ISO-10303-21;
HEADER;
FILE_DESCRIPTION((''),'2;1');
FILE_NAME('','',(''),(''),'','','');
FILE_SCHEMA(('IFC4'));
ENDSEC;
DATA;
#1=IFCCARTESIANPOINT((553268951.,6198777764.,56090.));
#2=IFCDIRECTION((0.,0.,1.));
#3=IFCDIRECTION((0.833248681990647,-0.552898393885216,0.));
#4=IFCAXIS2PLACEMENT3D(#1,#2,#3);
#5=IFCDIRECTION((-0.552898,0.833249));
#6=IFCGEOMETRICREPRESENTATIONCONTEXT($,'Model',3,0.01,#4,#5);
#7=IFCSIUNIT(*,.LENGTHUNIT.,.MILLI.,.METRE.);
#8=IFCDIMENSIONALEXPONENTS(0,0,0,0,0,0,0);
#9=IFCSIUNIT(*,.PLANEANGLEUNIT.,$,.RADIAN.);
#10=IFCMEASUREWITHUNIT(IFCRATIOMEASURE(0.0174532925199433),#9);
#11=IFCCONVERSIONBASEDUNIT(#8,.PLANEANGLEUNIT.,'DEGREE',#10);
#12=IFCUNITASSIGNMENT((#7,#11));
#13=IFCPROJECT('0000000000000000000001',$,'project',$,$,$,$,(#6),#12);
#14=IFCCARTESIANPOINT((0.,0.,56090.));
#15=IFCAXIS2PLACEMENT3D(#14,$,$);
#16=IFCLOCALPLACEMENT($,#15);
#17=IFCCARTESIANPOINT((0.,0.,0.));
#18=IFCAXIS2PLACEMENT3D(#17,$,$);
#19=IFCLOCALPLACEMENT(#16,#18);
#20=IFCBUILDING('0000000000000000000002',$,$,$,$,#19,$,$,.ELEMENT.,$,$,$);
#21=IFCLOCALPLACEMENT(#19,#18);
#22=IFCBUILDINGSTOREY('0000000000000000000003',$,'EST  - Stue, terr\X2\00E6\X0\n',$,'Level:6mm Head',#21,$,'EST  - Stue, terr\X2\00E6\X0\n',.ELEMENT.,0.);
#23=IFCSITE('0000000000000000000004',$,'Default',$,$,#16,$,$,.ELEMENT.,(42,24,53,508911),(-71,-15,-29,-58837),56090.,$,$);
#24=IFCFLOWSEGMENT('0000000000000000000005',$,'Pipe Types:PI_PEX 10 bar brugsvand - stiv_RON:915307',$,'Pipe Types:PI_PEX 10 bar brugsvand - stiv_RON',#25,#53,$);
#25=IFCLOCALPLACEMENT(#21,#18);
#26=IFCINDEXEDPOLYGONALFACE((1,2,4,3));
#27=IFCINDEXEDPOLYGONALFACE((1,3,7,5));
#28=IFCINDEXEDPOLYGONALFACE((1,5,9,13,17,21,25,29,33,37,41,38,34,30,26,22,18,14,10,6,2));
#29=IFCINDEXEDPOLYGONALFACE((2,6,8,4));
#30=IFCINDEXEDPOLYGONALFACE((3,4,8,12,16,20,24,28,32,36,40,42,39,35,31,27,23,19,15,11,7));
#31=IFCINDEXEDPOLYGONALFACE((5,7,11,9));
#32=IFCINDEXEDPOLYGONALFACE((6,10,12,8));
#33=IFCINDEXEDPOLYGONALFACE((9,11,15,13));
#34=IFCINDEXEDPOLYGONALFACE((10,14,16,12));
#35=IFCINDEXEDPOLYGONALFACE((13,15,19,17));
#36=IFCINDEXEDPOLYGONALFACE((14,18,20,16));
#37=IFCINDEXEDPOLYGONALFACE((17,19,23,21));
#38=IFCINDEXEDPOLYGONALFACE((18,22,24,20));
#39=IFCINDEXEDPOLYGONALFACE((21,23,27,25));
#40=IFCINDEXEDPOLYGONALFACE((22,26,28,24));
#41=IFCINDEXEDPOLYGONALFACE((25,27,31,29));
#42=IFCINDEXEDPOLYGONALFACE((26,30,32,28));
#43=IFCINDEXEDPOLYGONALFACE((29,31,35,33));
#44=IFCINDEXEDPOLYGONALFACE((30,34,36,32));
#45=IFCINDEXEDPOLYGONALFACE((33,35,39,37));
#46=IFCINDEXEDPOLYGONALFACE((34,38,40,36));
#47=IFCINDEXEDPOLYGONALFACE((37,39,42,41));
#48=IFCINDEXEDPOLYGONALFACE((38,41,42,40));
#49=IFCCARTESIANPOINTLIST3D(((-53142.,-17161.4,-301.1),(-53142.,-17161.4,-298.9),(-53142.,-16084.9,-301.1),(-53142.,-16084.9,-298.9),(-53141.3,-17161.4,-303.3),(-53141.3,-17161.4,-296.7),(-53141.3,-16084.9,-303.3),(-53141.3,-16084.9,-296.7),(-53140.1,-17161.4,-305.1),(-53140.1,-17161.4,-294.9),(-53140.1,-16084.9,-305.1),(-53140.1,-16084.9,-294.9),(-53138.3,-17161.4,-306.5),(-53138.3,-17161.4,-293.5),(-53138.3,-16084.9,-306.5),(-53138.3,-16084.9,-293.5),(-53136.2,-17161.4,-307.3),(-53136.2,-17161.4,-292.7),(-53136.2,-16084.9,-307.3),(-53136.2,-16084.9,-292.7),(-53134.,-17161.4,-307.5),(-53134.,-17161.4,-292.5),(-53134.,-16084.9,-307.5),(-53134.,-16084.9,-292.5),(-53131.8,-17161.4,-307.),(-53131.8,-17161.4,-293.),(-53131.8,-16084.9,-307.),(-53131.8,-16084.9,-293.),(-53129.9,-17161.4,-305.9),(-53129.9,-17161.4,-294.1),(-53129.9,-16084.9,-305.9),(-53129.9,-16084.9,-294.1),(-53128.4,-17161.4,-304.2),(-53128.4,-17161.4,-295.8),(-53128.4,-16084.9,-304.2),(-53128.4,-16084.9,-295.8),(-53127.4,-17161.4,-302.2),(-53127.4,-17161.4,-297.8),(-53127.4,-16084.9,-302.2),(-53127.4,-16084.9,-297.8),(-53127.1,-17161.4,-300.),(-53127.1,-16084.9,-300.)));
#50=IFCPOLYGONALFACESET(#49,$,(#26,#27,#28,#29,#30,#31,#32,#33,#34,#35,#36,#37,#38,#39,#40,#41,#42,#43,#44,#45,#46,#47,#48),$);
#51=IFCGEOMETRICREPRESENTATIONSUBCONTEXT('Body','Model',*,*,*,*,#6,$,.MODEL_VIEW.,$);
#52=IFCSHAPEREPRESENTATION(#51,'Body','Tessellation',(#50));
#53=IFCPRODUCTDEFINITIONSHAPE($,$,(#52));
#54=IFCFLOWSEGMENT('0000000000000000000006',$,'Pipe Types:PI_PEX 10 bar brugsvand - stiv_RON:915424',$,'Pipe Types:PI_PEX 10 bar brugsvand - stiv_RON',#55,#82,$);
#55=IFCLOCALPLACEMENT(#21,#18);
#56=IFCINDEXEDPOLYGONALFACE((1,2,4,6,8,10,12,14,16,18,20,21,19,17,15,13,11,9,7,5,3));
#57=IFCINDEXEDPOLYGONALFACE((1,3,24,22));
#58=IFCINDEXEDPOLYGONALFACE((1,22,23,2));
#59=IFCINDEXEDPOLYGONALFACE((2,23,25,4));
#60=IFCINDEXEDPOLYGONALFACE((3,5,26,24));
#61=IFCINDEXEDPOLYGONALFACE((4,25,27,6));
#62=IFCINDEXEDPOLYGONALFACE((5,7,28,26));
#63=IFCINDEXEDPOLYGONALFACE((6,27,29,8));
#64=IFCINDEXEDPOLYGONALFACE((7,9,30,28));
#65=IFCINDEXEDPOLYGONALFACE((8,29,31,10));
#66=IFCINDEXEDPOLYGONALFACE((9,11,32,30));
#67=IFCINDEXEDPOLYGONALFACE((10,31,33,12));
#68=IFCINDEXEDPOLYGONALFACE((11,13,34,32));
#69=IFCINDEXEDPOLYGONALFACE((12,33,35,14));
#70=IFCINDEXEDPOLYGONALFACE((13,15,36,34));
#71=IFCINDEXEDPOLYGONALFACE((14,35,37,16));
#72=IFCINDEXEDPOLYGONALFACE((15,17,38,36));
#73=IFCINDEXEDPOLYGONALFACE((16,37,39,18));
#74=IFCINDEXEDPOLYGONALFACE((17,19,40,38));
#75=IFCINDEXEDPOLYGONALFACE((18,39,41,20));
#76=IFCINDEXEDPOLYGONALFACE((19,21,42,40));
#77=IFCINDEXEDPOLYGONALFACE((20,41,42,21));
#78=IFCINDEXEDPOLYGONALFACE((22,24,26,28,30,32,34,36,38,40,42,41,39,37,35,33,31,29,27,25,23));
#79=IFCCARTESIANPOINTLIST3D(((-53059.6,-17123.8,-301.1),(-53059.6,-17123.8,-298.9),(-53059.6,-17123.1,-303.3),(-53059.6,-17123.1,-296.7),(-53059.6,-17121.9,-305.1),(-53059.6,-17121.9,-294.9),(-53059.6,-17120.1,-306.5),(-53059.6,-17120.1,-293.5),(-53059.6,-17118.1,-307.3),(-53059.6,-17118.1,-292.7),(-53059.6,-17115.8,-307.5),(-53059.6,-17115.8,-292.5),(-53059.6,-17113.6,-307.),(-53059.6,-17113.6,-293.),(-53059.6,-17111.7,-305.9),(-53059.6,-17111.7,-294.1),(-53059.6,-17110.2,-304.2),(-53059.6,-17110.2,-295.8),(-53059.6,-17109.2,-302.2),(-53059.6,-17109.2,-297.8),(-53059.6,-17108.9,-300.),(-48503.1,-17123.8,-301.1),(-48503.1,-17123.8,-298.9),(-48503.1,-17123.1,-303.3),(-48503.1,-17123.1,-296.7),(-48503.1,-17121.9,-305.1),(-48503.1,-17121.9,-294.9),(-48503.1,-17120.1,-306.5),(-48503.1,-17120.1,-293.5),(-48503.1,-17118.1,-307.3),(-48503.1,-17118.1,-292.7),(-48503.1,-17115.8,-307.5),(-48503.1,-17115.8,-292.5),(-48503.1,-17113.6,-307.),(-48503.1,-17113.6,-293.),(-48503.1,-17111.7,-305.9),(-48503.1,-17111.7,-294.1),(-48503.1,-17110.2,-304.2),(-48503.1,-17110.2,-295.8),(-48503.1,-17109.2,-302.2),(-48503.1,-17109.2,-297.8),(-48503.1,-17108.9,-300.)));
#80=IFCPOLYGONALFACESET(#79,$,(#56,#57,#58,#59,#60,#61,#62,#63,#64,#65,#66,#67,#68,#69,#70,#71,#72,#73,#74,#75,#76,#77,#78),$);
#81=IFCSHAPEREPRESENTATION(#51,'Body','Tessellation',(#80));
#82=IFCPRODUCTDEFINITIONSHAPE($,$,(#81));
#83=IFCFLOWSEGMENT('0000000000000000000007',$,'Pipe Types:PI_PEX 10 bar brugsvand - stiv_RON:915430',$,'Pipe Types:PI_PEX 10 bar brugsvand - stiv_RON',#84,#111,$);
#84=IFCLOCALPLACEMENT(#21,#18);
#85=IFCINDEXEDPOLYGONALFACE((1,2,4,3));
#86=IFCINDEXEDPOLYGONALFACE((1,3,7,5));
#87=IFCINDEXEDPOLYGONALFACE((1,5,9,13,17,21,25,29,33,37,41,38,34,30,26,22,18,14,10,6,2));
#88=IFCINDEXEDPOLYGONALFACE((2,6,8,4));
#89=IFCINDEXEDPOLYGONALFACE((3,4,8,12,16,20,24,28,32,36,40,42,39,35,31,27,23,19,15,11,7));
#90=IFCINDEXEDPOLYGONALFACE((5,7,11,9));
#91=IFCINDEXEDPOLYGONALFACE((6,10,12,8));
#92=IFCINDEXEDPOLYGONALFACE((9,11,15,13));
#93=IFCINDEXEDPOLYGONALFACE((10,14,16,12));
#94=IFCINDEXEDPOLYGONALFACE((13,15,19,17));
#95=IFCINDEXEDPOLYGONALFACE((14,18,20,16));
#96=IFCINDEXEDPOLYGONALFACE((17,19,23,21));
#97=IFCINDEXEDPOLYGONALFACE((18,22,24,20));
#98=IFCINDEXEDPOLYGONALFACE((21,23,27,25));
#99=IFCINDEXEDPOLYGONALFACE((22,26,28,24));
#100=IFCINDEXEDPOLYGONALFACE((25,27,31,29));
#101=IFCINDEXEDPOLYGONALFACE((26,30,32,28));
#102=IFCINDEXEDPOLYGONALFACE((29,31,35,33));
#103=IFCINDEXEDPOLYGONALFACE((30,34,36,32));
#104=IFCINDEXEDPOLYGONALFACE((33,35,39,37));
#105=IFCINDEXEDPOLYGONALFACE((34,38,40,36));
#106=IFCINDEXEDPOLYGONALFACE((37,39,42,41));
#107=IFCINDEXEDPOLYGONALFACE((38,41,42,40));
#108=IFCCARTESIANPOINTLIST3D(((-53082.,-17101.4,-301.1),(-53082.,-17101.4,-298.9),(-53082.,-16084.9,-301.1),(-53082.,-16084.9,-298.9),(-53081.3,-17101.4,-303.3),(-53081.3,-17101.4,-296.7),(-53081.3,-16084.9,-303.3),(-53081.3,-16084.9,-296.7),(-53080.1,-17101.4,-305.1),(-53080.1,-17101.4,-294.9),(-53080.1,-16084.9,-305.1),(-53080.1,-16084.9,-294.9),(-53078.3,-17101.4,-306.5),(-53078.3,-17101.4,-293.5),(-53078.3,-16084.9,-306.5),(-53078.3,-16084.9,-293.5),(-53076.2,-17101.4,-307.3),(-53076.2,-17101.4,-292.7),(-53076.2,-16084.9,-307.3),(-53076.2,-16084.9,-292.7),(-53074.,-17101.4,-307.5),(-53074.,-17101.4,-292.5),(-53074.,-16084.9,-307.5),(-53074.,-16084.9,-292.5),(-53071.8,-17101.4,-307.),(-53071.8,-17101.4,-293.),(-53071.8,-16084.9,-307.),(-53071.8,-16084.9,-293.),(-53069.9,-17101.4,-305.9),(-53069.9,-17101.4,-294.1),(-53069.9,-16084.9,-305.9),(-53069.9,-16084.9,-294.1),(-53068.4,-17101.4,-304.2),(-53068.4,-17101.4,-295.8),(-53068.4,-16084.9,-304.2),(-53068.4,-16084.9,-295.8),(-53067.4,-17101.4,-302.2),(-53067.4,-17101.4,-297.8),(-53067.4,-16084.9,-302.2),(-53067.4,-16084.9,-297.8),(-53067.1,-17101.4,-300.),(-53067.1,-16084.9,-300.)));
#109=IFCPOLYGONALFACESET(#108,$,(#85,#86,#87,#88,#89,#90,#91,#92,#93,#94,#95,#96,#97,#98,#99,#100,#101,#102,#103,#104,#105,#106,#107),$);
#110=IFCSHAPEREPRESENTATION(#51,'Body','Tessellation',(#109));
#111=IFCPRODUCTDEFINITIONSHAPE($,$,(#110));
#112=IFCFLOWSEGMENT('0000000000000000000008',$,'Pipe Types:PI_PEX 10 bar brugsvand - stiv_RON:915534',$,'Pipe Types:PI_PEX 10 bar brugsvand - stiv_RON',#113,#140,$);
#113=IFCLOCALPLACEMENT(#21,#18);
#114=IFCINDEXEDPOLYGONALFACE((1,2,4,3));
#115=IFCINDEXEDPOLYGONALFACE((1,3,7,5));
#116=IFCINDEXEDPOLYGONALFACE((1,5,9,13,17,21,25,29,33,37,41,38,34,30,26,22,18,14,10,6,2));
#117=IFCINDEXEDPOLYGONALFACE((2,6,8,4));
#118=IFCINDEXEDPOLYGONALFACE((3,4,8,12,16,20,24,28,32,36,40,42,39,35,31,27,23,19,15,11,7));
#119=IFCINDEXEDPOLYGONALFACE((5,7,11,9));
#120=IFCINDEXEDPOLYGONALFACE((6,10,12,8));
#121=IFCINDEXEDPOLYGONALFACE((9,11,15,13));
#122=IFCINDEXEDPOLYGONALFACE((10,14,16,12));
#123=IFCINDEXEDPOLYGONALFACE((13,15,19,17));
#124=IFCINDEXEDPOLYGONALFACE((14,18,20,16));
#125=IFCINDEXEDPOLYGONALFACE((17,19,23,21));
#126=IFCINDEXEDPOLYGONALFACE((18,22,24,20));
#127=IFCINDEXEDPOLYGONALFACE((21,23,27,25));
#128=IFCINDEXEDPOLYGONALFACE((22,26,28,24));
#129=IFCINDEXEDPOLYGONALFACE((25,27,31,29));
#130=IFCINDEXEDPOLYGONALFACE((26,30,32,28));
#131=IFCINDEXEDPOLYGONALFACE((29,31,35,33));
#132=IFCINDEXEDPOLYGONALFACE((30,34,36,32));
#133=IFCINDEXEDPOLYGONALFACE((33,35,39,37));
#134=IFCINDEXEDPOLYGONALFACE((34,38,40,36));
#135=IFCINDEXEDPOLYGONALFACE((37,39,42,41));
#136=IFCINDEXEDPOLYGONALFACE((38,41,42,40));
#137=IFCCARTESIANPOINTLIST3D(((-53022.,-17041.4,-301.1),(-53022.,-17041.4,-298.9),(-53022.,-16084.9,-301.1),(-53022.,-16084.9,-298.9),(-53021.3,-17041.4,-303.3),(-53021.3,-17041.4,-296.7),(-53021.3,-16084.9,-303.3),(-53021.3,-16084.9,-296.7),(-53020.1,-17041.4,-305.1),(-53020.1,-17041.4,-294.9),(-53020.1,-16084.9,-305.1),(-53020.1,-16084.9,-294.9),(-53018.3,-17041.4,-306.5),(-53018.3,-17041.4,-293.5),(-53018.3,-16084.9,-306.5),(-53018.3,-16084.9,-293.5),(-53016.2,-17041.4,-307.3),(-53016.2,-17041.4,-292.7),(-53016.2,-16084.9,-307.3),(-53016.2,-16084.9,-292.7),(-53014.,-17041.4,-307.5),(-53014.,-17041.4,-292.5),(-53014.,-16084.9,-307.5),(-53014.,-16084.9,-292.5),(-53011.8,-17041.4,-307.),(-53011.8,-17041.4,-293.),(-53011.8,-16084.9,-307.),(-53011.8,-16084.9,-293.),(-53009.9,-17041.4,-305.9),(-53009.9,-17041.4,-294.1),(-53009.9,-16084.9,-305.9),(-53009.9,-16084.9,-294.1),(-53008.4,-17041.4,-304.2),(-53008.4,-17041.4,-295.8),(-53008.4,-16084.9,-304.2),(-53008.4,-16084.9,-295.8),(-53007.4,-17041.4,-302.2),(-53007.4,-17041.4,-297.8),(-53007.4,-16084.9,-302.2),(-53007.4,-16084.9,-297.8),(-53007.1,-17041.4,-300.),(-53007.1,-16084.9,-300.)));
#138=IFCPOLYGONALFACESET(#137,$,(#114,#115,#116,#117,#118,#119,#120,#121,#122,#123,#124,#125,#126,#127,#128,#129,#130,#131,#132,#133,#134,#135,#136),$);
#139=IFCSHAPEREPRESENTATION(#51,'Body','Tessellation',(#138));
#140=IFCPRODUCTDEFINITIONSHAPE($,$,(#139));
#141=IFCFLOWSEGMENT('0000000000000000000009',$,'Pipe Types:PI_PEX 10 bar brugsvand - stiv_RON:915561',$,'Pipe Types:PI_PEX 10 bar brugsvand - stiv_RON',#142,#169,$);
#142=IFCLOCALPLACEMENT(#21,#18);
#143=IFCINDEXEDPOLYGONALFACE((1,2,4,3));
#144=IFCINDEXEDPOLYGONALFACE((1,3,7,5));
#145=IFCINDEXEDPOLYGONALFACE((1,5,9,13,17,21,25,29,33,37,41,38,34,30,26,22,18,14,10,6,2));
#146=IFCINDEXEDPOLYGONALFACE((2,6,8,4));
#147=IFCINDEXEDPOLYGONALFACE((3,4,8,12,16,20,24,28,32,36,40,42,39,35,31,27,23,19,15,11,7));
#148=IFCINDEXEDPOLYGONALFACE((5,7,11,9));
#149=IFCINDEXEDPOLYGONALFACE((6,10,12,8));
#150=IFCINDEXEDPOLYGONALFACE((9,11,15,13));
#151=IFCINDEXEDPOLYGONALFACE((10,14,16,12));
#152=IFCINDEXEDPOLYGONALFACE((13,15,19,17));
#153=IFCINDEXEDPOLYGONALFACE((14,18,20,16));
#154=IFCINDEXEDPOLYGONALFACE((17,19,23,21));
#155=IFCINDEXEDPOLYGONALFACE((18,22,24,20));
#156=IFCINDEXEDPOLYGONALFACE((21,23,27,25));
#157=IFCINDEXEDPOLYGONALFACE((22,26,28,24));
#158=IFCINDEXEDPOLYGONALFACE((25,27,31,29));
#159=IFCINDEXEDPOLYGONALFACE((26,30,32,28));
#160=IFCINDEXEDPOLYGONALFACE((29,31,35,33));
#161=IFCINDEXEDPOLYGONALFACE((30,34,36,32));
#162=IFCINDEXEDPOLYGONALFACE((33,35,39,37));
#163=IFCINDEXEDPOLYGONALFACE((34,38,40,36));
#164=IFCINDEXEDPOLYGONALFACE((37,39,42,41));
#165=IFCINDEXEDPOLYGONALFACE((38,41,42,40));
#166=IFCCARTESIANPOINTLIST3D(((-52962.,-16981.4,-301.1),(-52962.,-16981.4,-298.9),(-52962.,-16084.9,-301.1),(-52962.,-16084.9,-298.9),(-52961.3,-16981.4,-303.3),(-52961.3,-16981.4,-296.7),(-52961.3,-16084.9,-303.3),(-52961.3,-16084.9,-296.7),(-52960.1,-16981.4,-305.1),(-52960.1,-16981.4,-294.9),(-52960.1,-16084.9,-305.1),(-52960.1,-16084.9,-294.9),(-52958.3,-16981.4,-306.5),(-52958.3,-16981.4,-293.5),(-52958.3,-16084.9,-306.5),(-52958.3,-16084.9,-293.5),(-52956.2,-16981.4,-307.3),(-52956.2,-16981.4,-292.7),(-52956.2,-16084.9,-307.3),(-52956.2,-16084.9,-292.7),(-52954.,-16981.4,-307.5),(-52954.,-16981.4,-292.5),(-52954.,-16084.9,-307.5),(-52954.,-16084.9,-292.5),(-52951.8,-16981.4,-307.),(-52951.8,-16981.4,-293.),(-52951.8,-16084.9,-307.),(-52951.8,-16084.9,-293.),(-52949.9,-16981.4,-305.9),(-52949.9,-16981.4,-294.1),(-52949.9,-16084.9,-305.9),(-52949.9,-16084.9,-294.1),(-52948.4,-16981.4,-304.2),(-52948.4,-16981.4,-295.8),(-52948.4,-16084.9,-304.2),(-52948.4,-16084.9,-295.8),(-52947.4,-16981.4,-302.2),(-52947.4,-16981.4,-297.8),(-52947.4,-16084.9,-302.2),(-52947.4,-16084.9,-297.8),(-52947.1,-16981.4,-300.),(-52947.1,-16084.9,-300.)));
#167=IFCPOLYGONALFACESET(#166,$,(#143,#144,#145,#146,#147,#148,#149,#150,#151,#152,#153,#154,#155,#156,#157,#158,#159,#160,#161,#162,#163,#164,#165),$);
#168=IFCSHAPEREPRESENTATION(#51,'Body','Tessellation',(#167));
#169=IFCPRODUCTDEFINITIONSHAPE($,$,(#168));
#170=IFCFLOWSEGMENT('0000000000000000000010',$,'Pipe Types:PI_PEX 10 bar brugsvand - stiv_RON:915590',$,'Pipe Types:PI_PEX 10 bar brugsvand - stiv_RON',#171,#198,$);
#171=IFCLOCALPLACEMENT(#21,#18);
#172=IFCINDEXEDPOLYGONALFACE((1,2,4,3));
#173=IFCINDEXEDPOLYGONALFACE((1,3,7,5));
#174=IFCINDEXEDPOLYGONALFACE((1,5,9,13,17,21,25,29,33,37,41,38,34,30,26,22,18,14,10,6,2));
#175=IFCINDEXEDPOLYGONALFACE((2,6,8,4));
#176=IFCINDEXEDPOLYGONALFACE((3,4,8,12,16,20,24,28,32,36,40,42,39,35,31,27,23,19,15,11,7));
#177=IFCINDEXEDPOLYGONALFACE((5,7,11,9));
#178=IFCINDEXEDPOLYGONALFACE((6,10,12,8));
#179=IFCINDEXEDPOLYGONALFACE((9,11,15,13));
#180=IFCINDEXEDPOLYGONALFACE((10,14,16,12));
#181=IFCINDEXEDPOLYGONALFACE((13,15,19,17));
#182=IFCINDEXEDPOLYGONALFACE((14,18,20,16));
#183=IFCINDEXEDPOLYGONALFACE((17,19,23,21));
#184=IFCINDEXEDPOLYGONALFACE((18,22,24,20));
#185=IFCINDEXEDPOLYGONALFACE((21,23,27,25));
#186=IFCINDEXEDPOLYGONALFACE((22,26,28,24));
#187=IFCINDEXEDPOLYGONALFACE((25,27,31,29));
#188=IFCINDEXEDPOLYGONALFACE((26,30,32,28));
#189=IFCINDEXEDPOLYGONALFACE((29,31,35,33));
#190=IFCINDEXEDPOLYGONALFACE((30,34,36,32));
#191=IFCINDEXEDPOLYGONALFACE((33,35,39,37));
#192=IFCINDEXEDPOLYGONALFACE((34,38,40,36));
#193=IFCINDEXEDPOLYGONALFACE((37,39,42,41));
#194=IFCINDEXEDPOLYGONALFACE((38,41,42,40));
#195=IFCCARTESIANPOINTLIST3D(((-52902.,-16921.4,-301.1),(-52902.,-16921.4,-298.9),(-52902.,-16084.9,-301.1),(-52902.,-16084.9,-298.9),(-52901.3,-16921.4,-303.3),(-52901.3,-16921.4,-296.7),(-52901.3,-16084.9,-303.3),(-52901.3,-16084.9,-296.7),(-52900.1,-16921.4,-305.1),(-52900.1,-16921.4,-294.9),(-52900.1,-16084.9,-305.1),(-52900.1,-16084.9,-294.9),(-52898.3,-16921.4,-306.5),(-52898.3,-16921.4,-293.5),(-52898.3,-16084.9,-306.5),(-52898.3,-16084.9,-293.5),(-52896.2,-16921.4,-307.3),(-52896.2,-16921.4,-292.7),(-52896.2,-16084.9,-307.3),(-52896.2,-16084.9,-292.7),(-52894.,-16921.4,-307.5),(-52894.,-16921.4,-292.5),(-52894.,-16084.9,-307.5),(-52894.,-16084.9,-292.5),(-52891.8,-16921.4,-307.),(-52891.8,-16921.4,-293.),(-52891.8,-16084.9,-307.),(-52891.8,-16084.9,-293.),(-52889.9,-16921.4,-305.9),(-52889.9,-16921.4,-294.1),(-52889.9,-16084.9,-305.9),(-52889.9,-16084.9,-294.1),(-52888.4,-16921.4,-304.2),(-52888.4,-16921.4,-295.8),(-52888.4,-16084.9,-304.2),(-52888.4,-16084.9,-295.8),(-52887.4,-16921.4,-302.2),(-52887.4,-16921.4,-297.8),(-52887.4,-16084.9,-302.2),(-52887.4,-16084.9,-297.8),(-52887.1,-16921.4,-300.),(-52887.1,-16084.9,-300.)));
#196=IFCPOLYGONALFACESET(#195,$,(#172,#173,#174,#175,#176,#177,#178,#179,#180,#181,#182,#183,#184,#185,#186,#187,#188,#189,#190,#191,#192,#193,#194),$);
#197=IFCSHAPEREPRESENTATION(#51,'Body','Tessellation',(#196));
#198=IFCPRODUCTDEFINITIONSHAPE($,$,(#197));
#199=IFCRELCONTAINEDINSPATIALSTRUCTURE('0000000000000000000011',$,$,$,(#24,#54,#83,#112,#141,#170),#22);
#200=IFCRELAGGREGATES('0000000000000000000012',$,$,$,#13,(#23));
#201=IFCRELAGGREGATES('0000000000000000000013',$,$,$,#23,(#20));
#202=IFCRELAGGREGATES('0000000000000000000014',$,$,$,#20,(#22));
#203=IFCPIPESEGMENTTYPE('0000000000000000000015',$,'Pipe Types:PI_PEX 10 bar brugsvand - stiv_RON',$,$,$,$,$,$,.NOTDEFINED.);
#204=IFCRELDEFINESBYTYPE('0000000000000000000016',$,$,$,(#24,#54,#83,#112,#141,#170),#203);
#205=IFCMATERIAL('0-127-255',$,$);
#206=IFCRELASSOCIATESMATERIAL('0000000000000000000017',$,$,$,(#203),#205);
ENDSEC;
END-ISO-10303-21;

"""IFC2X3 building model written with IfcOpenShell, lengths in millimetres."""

from ifc_helpers import new_model, entity, si_unit, converted_unit, direction, frame, frame_2d, origin, origin_2d_with_axis, place, context, subcontext, project, spatial, circle, extrude, material, type_object, element, save


model = new_model("IFC2X3")

# Units and contexts
model_context = context("Model", 3, precision=0.01, world=frame((553268951.0, 6198777764.0, 56090.0), z_axis=(0.0, 0.0, 1.0), x_axis=(0.833248681990647, -0.552898393885216, 0.0)), true_north=direction((-0.552898, 0.833249)))
body_context = subcontext(model_context, "Body", "Model", "MODEL_VIEW")
ifc_project = project(units=[si_unit("LENGTHUNIT", "METRE", prefix="MILLI"), converted_unit("PLANEANGLEUNIT", "DEGREE", entity("IfcRatioMeasure", 0.0174532925199433), si_unit("PLANEANGLEUNIT", "RADIAN"), dimensions=[0, 0, 0, 0, 0, 0, 0])], contexts=[model_context])

# Site, building, storey
site_placement = place(None, frame((0.0, 0.0, 56090.0)))
site = spatial("IfcSite", under=ifc_project, at=site_placement, Name="Default", CompositionType="ELEMENT", RefLatitude=(42, 24, 53, 508911), RefLongitude=(-71, -15, -29, -58837), RefElevation=56090.0)
building_placement = place(site_placement, origin())
building = spatial("IfcBuilding", under=site, at=building_placement, CompositionType="ELEMENT")
storey_placement = place(building_placement, frame((0.0, 0.0, 0.0)))
storey = spatial("IfcBuildingStorey", under=building, at=storey_placement, Name="EST  - Stue, terræn", ObjectType="Level:6mm Head", LongName="EST  - Stue, terræn", CompositionType="ELEMENT", Elevation=0.0)

# Flow segments
ifc_material_1 = material(Name="0-127-255")
pipe_segment_type_1 = type_object("IfcPipeSegmentType", Name="Pipe Types:PI_PEX 10 bar brugsvand - stiv_RON", PredefinedType="NOTDEFINED", material=ifc_material_1)
flow_segment_1_placement = place(storey_placement, origin())
element("IfcFlowSegment", 1, at=flow_segment_1_placement, inside=storey, type_object=pipe_segment_type_1, Name="Pipe Types:PI_PEX 10 bar brugsvand - stiv_RON:915307", ObjectType="Pipe Types:PI_PEX 10 bar brugsvand - stiv_RON", context=body_context, shape_type="SweptSolid", body=[
    extrude(circle(Radius=7.5, at=origin_2d_with_axis()), frame((-53134.6, -17161.4, -300.0), z_axis=(0.0, 1.0, 0.0), x_axis=(1.0, 0.0, 0.0)), (0.0, 0.0, 1.0), 1076.5),
])
flow_segment_2_placement = place(storey_placement, origin())
element("IfcFlowSegment", 2, at=flow_segment_2_placement, inside=storey, type_object=pipe_segment_type_1, Name="Pipe Types:PI_PEX 10 bar brugsvand - stiv_RON:915424", ObjectType="Pipe Types:PI_PEX 10 bar brugsvand - stiv_RON", context=body_context, shape_type="SweptSolid", body=[
    extrude(circle(Radius=7.5, at=frame_2d((0.0, 0.0), x_axis=(1.0, 0.0))), frame((-53059.6, -17116.4, -300.0), z_axis=(1.0, 0.0, 0.0), x_axis=(0.0, 1.0, 0.0)), (0.0, 0.0, 1.0), 4556.5),
])
flow_segment_3_placement = place(storey_placement, origin())
element("IfcFlowSegment", 3, at=flow_segment_3_placement, inside=storey, type_object=pipe_segment_type_1, Name="Pipe Types:PI_PEX 10 bar brugsvand - stiv_RON:915430", ObjectType="Pipe Types:PI_PEX 10 bar brugsvand - stiv_RON", context=body_context, shape_type="SweptSolid", body=[
    extrude(circle(Radius=7.5, at=origin_2d_with_axis()), frame((-53074.6, -17101.4, -300.0), z_axis=(0.0, 1.0, 0.0), x_axis=(1.0, 0.0, 0.0)), (0.0, 0.0, 1.0), 1016.5),
])
flow_segment_4_placement = place(storey_placement, origin())
element("IfcFlowSegment", 4, at=flow_segment_4_placement, inside=storey, type_object=pipe_segment_type_1, Name="Pipe Types:PI_PEX 10 bar brugsvand - stiv_RON:915534", ObjectType="Pipe Types:PI_PEX 10 bar brugsvand - stiv_RON", context=body_context, shape_type="SweptSolid", body=[
    extrude(circle(Radius=7.5, at=origin_2d_with_axis()), frame((-53014.6, -17041.4, -300.0), z_axis=(0.0, 1.0, 0.0), x_axis=(1.0, 0.0, 0.0)), (0.0, 0.0, 1.0), 956.5),
])
flow_segment_5_placement = place(storey_placement, origin())
element("IfcFlowSegment", 5, at=flow_segment_5_placement, inside=storey, type_object=pipe_segment_type_1, Name="Pipe Types:PI_PEX 10 bar brugsvand - stiv_RON:915561", ObjectType="Pipe Types:PI_PEX 10 bar brugsvand - stiv_RON", context=body_context, shape_type="SweptSolid", body=[
    extrude(circle(Radius=7.5, at=frame_2d((0.0, 0.0), x_axis=(1.0, 0.0))), frame((-52954.6, -16981.4, -300.0), z_axis=(0.0, 1.0, 0.0), x_axis=(1.0, 0.0, 0.0)), (0.0, 0.0, 1.0), 896.5),
])
flow_segment_6_placement = place(storey_placement, origin())
element("IfcFlowSegment", 6, at=flow_segment_6_placement, inside=storey, type_object=pipe_segment_type_1, Name="Pipe Types:PI_PEX 10 bar brugsvand - stiv_RON:915590", ObjectType="Pipe Types:PI_PEX 10 bar brugsvand - stiv_RON", context=body_context, shape_type="SweptSolid", body=[
    extrude(circle(Radius=7.5, at=origin_2d_with_axis()), frame((-52894.6, -16921.4, -300.0), z_axis=(0.0, 1.0, 0.0), x_axis=(1.0, 0.0, 0.0)), (0.0, 0.0, 1.0), 836.5),
])

save(model, "model.ifc")
